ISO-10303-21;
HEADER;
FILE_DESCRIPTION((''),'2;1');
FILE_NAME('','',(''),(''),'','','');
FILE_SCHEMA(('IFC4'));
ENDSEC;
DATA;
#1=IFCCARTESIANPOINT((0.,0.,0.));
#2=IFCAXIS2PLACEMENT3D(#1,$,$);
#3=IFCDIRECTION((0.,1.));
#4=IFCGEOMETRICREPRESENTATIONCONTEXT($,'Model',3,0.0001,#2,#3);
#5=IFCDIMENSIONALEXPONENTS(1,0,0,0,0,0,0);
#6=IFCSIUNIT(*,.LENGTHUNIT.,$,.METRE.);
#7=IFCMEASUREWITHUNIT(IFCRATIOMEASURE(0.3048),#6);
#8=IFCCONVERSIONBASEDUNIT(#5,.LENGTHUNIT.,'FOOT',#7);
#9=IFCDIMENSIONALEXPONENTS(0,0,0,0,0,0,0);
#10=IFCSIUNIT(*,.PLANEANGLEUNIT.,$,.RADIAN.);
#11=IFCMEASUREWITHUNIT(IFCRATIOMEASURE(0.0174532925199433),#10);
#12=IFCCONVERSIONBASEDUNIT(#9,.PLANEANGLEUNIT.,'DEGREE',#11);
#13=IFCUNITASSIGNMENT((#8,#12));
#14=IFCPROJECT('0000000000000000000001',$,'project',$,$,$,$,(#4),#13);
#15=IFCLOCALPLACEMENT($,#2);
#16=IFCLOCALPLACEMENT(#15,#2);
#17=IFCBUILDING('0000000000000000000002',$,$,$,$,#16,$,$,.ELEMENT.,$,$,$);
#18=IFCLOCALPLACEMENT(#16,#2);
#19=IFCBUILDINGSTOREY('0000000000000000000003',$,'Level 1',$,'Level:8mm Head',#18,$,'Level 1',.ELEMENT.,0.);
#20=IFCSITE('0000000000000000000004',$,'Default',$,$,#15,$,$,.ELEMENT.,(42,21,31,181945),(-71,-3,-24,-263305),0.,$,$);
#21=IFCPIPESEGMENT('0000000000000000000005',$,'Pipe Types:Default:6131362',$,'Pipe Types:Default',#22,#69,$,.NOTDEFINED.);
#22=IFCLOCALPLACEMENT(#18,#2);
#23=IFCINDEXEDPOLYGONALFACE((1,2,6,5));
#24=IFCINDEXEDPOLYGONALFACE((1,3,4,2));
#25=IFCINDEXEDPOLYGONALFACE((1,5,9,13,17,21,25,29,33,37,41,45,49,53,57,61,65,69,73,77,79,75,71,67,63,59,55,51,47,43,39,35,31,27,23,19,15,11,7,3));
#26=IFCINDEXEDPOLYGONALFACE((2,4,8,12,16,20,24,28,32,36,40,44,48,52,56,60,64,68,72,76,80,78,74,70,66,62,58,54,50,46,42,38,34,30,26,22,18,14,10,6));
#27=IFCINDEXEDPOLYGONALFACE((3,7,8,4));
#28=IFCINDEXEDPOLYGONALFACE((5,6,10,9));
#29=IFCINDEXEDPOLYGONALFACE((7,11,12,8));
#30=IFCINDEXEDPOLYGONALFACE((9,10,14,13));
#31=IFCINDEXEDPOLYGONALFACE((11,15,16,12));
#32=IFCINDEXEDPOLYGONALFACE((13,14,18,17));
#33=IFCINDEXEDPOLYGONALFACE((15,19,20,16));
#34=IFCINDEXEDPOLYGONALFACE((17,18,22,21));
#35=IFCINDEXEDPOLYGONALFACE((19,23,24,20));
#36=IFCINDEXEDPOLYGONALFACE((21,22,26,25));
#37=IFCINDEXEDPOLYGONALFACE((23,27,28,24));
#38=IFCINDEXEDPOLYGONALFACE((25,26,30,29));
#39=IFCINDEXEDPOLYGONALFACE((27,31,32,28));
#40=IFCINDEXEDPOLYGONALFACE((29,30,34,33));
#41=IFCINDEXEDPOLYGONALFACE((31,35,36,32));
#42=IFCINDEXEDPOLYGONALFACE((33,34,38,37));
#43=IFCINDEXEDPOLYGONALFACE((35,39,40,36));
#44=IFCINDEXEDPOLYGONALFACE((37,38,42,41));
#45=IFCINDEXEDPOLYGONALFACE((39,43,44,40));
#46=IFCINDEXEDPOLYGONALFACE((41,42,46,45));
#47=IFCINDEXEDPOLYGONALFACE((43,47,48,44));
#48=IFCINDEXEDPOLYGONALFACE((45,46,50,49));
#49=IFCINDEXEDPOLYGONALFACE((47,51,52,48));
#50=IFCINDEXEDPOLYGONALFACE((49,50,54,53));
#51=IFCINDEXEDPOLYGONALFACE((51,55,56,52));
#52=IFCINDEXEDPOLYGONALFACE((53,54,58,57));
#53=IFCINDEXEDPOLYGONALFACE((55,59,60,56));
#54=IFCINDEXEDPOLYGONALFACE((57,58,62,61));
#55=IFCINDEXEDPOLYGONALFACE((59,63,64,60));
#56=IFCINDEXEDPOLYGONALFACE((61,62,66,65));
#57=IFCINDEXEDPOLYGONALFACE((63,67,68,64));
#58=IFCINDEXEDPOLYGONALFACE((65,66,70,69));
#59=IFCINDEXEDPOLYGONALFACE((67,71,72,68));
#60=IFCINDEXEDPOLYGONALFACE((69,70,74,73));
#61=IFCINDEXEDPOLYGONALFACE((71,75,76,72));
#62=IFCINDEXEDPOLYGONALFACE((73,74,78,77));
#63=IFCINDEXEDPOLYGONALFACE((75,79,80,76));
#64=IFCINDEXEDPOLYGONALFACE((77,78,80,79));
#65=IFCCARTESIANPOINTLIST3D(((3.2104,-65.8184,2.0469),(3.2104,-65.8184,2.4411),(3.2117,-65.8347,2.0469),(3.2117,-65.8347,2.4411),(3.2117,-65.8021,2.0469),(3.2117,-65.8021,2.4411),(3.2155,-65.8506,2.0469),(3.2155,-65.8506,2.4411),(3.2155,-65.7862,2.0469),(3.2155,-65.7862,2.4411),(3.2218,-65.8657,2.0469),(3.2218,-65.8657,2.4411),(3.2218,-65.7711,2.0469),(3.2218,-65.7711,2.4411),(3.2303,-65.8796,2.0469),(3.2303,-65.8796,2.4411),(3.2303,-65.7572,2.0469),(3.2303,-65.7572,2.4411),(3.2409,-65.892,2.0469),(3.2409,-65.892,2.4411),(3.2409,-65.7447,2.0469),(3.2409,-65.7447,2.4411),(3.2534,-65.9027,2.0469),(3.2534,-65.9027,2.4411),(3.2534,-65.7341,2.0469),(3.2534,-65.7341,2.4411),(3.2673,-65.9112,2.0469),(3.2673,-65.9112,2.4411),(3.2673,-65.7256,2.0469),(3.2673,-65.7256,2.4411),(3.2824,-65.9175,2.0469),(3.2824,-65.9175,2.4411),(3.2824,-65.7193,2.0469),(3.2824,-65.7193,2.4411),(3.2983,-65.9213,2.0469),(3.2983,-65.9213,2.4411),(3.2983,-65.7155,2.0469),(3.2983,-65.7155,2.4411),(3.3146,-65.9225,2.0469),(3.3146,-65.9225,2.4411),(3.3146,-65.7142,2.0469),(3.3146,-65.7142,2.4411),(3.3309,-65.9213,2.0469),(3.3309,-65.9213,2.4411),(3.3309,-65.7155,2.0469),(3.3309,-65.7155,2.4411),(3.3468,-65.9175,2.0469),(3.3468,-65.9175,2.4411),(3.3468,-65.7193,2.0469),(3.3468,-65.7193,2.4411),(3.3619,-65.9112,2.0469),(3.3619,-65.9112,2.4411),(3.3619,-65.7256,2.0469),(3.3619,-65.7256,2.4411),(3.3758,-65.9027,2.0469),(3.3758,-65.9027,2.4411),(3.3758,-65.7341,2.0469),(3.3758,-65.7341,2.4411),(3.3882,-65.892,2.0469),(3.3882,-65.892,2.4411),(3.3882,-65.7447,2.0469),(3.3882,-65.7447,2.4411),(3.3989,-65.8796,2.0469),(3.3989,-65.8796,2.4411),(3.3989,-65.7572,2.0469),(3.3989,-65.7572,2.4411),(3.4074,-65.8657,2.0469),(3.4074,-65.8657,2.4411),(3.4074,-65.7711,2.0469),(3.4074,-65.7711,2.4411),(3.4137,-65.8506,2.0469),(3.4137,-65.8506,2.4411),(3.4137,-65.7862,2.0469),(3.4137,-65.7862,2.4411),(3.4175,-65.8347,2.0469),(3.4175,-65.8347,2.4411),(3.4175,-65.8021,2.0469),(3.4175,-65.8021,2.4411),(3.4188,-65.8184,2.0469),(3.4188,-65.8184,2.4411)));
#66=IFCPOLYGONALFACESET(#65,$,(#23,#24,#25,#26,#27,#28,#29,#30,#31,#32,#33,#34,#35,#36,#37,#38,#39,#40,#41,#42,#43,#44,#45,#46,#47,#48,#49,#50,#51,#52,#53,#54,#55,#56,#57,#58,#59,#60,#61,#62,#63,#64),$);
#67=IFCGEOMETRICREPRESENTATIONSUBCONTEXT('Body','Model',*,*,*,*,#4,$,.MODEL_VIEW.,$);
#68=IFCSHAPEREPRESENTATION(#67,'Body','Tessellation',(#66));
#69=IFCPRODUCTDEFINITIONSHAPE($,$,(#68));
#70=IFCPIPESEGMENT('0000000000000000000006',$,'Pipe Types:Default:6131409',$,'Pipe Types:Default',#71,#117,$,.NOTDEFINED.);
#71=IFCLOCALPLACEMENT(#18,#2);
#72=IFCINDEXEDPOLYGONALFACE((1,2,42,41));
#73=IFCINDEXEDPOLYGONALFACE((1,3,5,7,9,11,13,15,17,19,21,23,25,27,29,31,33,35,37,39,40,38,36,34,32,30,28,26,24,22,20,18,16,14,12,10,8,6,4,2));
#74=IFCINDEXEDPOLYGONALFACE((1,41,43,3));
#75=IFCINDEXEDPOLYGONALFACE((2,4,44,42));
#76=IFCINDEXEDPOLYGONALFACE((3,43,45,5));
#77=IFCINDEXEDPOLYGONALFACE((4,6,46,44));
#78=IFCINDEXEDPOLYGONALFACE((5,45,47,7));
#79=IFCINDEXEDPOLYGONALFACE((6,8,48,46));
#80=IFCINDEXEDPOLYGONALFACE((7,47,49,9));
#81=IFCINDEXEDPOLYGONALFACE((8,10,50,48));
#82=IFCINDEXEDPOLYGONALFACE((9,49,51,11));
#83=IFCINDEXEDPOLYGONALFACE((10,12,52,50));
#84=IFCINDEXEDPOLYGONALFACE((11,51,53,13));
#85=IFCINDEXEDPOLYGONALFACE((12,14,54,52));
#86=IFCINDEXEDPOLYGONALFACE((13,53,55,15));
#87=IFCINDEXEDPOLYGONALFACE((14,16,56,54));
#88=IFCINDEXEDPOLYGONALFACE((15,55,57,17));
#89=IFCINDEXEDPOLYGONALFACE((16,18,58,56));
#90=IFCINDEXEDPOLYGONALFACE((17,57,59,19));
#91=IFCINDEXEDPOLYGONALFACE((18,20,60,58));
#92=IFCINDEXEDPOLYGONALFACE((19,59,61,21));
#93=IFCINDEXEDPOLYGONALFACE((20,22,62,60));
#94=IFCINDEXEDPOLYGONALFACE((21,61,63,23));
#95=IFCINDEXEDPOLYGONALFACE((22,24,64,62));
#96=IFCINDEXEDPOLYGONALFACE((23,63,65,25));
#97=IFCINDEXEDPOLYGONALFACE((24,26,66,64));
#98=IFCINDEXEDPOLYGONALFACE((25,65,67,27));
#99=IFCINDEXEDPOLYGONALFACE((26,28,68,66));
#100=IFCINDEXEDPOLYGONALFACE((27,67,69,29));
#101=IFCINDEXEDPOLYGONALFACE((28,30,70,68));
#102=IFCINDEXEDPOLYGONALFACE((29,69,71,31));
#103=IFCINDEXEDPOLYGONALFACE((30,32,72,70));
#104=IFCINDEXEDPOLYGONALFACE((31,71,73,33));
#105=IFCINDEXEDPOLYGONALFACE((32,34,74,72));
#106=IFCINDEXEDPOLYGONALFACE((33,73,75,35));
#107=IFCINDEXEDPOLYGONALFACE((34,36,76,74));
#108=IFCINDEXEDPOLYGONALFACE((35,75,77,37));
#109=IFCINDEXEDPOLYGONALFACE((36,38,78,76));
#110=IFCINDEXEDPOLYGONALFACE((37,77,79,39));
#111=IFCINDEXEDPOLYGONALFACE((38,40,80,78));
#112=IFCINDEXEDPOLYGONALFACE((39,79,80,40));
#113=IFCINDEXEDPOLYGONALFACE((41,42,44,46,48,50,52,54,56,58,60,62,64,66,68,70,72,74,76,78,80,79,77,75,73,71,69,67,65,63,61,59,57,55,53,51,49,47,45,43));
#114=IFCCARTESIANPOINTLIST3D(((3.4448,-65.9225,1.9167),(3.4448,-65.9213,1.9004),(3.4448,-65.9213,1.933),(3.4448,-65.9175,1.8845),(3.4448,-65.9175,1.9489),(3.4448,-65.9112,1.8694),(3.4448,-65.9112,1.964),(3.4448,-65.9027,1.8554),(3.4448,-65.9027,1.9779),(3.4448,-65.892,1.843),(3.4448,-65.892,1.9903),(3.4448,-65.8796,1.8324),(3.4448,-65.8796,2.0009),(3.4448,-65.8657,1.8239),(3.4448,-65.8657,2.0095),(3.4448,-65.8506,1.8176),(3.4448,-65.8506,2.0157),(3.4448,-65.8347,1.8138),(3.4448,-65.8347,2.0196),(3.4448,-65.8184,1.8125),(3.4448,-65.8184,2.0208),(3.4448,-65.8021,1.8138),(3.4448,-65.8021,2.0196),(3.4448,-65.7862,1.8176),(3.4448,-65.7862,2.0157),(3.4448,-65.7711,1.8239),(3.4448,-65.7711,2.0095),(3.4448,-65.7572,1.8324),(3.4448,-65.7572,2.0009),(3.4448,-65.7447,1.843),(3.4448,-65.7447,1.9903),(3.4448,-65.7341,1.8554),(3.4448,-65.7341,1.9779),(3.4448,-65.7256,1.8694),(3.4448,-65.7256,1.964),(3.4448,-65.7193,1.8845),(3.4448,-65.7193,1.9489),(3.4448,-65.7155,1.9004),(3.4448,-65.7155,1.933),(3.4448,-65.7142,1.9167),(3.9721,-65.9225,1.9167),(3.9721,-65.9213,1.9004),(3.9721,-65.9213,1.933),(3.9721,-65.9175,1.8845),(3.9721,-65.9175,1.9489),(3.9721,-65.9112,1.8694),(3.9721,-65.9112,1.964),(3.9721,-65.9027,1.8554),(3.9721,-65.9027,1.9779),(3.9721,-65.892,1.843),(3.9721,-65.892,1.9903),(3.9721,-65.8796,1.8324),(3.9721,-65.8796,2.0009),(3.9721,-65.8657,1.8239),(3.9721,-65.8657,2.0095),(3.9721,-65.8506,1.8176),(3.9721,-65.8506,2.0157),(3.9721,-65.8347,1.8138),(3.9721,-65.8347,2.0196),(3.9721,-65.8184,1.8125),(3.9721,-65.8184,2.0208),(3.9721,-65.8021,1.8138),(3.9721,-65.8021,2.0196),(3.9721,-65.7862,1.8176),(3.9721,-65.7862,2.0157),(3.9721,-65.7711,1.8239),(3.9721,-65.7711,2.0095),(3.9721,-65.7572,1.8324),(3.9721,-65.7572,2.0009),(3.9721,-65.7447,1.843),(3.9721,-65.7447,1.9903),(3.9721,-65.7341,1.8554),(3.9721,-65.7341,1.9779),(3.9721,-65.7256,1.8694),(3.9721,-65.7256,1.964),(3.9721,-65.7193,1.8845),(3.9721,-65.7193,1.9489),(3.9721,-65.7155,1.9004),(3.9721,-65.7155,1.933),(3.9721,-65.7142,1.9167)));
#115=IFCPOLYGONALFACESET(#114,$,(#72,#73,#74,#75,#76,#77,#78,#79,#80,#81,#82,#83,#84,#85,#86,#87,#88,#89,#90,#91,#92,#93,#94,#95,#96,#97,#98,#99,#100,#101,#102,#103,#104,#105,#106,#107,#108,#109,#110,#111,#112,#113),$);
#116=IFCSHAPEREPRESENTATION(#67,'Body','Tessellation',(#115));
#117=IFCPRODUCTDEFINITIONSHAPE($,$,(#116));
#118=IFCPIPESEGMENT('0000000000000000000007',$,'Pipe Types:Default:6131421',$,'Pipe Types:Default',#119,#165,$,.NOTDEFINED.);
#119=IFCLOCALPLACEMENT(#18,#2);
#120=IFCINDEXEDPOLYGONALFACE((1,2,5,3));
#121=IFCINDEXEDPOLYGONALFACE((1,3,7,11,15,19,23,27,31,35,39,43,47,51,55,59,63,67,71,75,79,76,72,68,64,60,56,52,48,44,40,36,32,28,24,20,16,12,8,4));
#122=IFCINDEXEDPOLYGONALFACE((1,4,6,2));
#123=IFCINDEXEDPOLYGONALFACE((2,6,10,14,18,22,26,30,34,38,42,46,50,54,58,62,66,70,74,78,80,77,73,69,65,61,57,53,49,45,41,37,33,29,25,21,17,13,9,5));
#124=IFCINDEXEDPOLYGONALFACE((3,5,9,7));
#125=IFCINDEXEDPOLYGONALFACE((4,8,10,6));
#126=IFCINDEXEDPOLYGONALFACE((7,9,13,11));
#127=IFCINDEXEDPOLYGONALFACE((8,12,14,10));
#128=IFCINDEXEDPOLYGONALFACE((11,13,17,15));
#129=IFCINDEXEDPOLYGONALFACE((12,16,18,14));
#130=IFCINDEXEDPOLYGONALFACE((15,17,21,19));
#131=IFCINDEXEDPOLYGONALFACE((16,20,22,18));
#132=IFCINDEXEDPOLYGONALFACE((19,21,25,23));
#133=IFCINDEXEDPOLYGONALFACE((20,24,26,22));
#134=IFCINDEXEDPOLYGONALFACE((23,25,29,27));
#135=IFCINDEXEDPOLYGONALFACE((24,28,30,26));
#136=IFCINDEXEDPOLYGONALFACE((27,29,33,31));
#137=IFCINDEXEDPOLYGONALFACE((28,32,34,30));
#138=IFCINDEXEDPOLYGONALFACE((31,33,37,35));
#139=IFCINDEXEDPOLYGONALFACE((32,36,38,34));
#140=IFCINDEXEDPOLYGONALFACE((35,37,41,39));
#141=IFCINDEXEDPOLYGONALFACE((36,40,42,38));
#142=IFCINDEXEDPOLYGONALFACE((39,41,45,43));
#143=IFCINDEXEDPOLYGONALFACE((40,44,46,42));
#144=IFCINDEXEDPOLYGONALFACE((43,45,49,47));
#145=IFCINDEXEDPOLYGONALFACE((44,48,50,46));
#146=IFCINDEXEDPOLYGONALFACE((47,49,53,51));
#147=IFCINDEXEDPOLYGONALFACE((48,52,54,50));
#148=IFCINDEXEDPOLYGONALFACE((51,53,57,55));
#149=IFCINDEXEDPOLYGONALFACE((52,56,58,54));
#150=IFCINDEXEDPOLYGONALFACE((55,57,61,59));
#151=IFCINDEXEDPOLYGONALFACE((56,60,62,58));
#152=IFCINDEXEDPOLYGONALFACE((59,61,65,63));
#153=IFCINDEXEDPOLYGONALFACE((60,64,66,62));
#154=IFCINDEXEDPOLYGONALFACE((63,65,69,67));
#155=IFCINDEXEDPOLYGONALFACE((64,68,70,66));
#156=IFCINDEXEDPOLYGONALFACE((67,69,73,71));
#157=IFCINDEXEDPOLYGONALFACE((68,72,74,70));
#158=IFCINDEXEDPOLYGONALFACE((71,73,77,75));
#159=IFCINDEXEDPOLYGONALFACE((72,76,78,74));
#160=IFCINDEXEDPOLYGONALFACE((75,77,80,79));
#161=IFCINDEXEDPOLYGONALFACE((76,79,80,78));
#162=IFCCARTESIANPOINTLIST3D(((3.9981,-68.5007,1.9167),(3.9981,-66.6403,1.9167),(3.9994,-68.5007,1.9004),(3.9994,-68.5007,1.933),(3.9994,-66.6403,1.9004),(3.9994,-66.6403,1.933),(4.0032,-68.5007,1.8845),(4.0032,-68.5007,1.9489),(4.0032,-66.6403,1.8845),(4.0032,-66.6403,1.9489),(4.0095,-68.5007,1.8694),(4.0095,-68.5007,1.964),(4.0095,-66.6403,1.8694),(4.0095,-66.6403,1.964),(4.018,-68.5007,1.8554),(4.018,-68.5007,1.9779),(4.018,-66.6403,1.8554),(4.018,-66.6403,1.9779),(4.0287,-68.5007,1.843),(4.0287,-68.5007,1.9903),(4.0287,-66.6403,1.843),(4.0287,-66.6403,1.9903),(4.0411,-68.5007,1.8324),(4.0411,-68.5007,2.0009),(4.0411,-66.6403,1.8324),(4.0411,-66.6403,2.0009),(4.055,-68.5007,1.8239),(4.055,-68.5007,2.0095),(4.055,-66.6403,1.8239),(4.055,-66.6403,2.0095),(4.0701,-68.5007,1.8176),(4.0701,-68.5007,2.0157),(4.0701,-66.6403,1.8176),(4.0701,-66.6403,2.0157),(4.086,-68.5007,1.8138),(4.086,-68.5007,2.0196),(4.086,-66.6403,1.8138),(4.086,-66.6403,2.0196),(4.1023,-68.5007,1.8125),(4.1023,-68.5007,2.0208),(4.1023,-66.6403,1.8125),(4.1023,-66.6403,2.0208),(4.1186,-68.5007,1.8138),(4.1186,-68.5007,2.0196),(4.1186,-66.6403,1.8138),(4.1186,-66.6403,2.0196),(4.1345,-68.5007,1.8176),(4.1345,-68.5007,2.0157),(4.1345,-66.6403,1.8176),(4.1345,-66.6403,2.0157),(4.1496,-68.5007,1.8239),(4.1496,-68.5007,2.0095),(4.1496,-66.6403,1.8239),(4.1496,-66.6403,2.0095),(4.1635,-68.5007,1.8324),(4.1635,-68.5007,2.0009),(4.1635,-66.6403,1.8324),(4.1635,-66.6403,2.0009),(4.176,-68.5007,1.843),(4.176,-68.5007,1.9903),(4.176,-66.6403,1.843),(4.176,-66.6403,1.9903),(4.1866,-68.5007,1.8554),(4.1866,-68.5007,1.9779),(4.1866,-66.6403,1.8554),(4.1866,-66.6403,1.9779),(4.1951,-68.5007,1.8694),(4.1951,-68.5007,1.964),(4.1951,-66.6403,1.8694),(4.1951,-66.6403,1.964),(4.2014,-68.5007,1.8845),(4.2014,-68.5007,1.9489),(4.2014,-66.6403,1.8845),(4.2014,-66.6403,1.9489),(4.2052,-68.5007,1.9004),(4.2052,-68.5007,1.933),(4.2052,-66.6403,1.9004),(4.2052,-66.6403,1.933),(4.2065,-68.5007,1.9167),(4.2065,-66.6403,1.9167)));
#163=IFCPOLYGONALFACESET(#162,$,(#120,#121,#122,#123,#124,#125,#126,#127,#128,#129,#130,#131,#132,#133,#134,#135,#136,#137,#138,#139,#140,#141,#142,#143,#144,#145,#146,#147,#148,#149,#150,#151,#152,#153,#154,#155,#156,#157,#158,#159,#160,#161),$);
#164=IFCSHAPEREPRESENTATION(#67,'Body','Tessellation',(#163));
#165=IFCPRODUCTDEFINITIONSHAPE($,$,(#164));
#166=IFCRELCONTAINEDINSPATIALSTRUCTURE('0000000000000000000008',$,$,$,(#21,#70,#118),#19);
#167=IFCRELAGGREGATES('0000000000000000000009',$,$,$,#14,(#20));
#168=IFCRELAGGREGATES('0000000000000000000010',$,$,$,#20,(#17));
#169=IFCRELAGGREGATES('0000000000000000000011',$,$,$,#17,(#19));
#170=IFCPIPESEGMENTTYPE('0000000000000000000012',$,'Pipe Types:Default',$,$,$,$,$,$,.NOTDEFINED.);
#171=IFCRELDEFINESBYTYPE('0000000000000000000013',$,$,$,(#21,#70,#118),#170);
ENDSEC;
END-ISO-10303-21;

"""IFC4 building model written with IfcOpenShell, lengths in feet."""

from ifc_helpers import new_model, entity, si_unit, converted_unit, direction, frame, origin, place, context, subcontext, project, spatial, indexed_curve, outline, extrude, type_object, element, save


model = new_model("IFC4")

# Units and contexts
model_context = context("Model", 3, precision=0.0001, world=origin(), true_north=direction((0.0, 1.0)))
body_context = subcontext(model_context, "Body", "Model", "MODEL_VIEW")
ifc_project = project(units=[converted_unit("LENGTHUNIT", "FOOT", entity("IfcRatioMeasure", 0.3048), si_unit("LENGTHUNIT", "METRE"), dimensions=[1, 0, 0, 0, 0, 0, 0]), converted_unit("PLANEANGLEUNIT", "DEGREE", entity("IfcRatioMeasure", 0.0174532925199433), si_unit("PLANEANGLEUNIT", "RADIAN"), dimensions=[0, 0, 0, 0, 0, 0, 0])], contexts=[model_context])

# Site, building, storey
site_placement = place(None, origin())
site = spatial("IfcSite", under=ifc_project, at=site_placement, Name="Default", CompositionType="ELEMENT", RefLatitude=(42, 21, 31, 181945), RefLongitude=(-71, -3, -24, -263305), RefElevation=0.0)
building_placement = place(site_placement, origin())
building = spatial("IfcBuilding", under=site, at=building_placement, CompositionType="ELEMENT")
storey_placement = place(building_placement, origin())
storey = spatial("IfcBuildingStorey", under=building, at=storey_placement, Name="Level 1", ObjectType="Level:8mm Head", LongName="Level 1", CompositionType="ELEMENT", Elevation=0.0)

# Pipe segments
pipe_segment_type = type_object("IfcPipeSegmentType", Name="Pipe Types:Default", PredefinedType="NOTDEFINED")
pipe_segment_1_placement = place(storey_placement, origin())
element("IfcPipeSegment", 1, at=pipe_segment_1_placement, inside=storey, type_object=pipe_segment_type, Name="Pipe Types:Default:6131362", ObjectType="Pipe Types:Default", PredefinedType="NOTDEFINED", context=body_context, shape_type="SweptSolid", body=[
    extrude(outline(indexed_curve([(0.1042, 0.0), (0.1029, 0.0163), (0.0991, 0.0322), (0.0928, 0.0473), (0.0843, 0.0612), (0.0737, 0.0737), (0.0612, 0.0843), (0.0473, 0.0928), (0.0322, 0.0991), (0.0163, 0.1029), (0.0, 0.1042), (-0.0163, 0.1029), (-0.0322, 0.0991), (-0.0473, 0.0928), (-0.0612, 0.0843), (-0.0737, 0.0737), (-0.0843, 0.0612), (-0.0928, 0.0473), (-0.0991, 0.0322), (-0.1029, 0.0163), (-0.1042, 0.0), (-0.1029, -0.0163), (-0.0991, -0.0322), (-0.0928, -0.0473), (-0.0843, -0.0612), (-0.0737, -0.0737), (-0.0612, -0.0843), (-0.0473, -0.0928), (-0.0322, -0.0991), (-0.0163, -0.1029), (0.0, -0.1042), (0.0163, -0.1029), (0.0322, -0.0991), (0.0473, -0.0928), (0.0612, -0.0843), (0.0737, -0.0737), (0.0843, -0.0612), (0.0928, -0.0473), (0.0991, -0.0322), (0.1029, -0.0163), (0.1042, 0.0)], self_intersect=False)), frame((3.3146, -65.8184, 2.0469)), (0.0, 0.0, 1.0), 0.3942),
])
pipe_segment_2_placement = place(storey_placement, origin())
element("IfcPipeSegment", 2, at=pipe_segment_2_placement, inside=storey, type_object=pipe_segment_type, Name="Pipe Types:Default:6131409", ObjectType="Pipe Types:Default", PredefinedType="NOTDEFINED", context=body_context, shape_type="SweptSolid", body=[
    extrude(outline(indexed_curve([(0.1042, 0.0), (0.1029, 0.0163), (0.0991, 0.0322), (0.0928, 0.0473), (0.0843, 0.0612), (0.0737, 0.0737), (0.0612, 0.0843), (0.0473, 0.0928), (0.0322, 0.0991), (0.0163, 0.1029), (0.0, 0.1042), (-0.0163, 0.1029), (-0.0322, 0.0991), (-0.0473, 0.0928), (-0.0612, 0.0843), (-0.0737, 0.0737), (-0.0843, 0.0612), (-0.0928, 0.0473), (-0.0991, 0.0322), (-0.1029, 0.0163), (-0.1042, 0.0), (-0.1029, -0.0163), (-0.0991, -0.0322), (-0.0928, -0.0473), (-0.0843, -0.0612), (-0.0737, -0.0737), (-0.0612, -0.0843), (-0.0473, -0.0928), (-0.0322, -0.0991), (-0.0163, -0.1029), (0.0, -0.1042), (0.0163, -0.1029), (0.0322, -0.0991), (0.0473, -0.0928), (0.0612, -0.0843), (0.0737, -0.0737), (0.0843, -0.0612), (0.0928, -0.0473), (0.0991, -0.0322), (0.1029, -0.0163), (0.1042, 0.0)], self_intersect=False)), frame((3.4448, -65.8184, 1.9167), z_axis=(1.0, 0.0, 0.0), x_axis=(0.0, -1.0, 0.0)), (0.0, 0.0, 1.0), 0.5273),
])
pipe_segment_3_placement = place(storey_placement, origin())
element("IfcPipeSegment", 3, at=pipe_segment_3_placement, inside=storey, type_object=pipe_segment_type, Name="Pipe Types:Default:6131421", ObjectType="Pipe Types:Default", PredefinedType="NOTDEFINED", context=body_context, shape_type="SweptSolid", body=[
    extrude(outline(indexed_curve([(0.1042, 0.0), (0.1029, 0.0163), (0.0991, 0.0322), (0.0928, 0.0473), (0.0843, 0.0612), (0.0737, 0.0737), (0.0612, 0.0843), (0.0473, 0.0928), (0.0322, 0.0991), (0.0163, 0.1029), (0.0, 0.1042), (-0.0163, 0.1029), (-0.0322, 0.0991), (-0.0473, 0.0928), (-0.0612, 0.0843), (-0.0737, 0.0737), (-0.0843, 0.0612), (-0.0928, 0.0473), (-0.0991, 0.0322), (-0.1029, 0.0163), (-0.1042, 0.0), (-0.1029, -0.0163), (-0.0991, -0.0322), (-0.0928, -0.0473), (-0.0843, -0.0612), (-0.0737, -0.0737), (-0.0612, -0.0843), (-0.0473, -0.0928), (-0.0322, -0.0991), (-0.0163, -0.1029), (0.0, -0.1042), (0.0163, -0.1029), (0.0322, -0.0991), (0.0473, -0.0928), (0.0612, -0.0843), (0.0737, -0.0737), (0.0843, -0.0612), (0.0928, -0.0473), (0.0991, -0.0322), (0.1029, -0.0163), (0.1042, 0.0)], self_intersect=False)), frame((4.1023, -68.5007, 1.9167), z_axis=(0.0, 1.0, 0.0), x_axis=(-1.0, 0.0, 0.0)), (0.0, 0.0, 1.0), 1.8603),
])

save(model, "model.ifc")
